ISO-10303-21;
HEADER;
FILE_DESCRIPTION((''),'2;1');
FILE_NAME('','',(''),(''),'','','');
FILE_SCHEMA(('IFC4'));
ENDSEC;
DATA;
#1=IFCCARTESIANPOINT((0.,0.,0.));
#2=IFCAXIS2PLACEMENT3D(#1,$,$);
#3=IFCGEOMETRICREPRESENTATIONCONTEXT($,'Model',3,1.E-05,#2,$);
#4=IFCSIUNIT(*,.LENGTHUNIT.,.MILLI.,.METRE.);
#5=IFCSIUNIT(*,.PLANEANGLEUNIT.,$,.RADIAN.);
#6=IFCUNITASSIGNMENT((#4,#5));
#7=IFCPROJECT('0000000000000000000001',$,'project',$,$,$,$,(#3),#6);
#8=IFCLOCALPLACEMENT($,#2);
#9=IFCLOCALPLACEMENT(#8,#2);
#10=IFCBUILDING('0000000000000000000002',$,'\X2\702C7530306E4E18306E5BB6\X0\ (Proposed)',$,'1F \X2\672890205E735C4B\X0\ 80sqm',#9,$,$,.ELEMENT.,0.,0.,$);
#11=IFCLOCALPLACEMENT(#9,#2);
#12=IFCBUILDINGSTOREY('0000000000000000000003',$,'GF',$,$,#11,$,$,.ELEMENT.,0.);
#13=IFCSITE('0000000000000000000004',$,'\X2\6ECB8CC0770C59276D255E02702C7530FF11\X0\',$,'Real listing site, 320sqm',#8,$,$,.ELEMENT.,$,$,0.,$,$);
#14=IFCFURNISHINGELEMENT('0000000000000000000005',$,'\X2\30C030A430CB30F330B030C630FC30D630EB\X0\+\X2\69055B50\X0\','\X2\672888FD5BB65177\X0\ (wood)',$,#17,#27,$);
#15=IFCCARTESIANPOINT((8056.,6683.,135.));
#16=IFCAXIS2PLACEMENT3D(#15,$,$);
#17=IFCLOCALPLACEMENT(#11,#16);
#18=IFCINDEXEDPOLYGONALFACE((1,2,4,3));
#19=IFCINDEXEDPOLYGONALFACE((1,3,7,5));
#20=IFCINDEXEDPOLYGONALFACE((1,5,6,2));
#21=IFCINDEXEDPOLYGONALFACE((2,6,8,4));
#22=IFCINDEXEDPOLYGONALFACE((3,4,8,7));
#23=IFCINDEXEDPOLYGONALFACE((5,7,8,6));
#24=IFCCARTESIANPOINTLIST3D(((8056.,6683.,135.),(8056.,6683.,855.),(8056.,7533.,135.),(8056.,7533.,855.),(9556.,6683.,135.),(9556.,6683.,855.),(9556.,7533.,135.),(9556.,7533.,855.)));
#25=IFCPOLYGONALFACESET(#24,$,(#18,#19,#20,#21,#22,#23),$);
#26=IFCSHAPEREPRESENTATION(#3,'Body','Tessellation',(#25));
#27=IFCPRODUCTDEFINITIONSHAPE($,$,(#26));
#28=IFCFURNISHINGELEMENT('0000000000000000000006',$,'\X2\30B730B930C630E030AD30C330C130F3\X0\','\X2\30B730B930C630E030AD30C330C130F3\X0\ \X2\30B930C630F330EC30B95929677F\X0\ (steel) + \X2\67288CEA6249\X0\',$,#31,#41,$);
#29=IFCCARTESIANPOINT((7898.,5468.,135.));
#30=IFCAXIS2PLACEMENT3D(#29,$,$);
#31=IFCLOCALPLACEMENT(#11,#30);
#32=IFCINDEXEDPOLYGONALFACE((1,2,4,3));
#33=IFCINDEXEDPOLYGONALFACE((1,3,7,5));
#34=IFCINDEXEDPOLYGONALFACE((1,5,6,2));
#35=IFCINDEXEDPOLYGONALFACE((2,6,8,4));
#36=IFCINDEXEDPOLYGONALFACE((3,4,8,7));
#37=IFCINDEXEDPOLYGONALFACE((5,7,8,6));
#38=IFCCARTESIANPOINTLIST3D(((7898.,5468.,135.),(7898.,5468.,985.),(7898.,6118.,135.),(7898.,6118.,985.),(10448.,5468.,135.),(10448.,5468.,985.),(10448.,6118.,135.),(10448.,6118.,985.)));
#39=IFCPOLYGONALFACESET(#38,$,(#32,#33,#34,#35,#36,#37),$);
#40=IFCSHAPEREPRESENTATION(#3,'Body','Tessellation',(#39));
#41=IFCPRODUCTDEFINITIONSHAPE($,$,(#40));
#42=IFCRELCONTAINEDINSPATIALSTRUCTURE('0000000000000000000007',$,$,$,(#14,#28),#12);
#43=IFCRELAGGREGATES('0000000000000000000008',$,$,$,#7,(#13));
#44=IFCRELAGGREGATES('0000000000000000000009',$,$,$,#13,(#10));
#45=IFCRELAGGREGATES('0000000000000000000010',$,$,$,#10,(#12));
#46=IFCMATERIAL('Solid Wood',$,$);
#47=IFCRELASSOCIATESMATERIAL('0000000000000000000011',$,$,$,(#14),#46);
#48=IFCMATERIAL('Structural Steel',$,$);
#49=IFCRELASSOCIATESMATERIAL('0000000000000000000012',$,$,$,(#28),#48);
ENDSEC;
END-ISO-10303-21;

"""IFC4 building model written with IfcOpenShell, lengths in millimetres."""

from ifc_helpers import new_model, si_unit, frame, frame_2d, origin, place, context, project, spatial, rectangle, extrude, material, element, save


model = new_model("IFC4")

# Units and contexts
model_context = context("Model", 3, precision=1e-05, world=origin())
ifc_project = project(units=[si_unit("LENGTHUNIT", "METRE", prefix="MILLI"), si_unit("PLANEANGLEUNIT", "RADIAN")], contexts=[model_context])

# Site, building, storey
site_placement = place(None, origin())
site = spatial("IfcSite", under=ifc_project, at=site_placement, Name="滋賀県大津市瀬田１", ObjectType="Real listing site, 320sqm", CompositionType="ELEMENT", RefElevation=0.0)
building_placement = place(site_placement, origin())
building = spatial("IfcBuilding", under=site, at=building_placement, Name="瀬田の丘の家 (Proposed)", ObjectType="1F 木造平屋 80sqm", CompositionType="ELEMENT", ElevationOfRefHeight=0.0, ElevationOfTerrain=0.0)
storey_placement = place(building_placement, origin())
storey = spatial("IfcBuildingStorey", under=building, at=storey_placement, Name="GF", CompositionType="ELEMENT", Elevation=0.0)

# Shared definitions
ifc_material_1 = material(Name="Solid Wood")

# Shared definitions
ifc_material_2 = material(Name="Structural Steel")

# Furnishing elements
furnishing_1_placement = place(storey_placement, frame((8056.0, 6683.0, 135.0)))
element("IfcFurnishingElement", 1, at=furnishing_1_placement, inside=storey, material=ifc_material_1, Name="ダイニングテーブル+椅子", Description="木製家具 (wood)", context=model_context, shape_type="SweptSolid", body=[
    extrude(rectangle(XDim=1500.0, YDim=850.0, at=frame_2d((750.0, 425.0))), frame((8056.0, 6683.0, 135.0)), (0.0, 0.0, 1.0), 720.0),
])
furnishing_2_placement = place(storey_placement, frame((7898.0, 5468.0, 135.0)))
element("IfcFurnishingElement", 2, at=furnishing_2_placement, inside=storey, material=ifc_material_2, Name="システムキッチン", Description="システムキッチン ステンレス天板 (steel) + 木質扉", context=model_context, shape_type="SweptSolid", body=[
    extrude(rectangle(XDim=2550.0, YDim=650.0, at=frame_2d((1275.0, 325.0))), frame((7898.0, 5468.0, 135.0)), (0.0, 0.0, 1.0), 850.0),
])

save(model, "model.ifc")
